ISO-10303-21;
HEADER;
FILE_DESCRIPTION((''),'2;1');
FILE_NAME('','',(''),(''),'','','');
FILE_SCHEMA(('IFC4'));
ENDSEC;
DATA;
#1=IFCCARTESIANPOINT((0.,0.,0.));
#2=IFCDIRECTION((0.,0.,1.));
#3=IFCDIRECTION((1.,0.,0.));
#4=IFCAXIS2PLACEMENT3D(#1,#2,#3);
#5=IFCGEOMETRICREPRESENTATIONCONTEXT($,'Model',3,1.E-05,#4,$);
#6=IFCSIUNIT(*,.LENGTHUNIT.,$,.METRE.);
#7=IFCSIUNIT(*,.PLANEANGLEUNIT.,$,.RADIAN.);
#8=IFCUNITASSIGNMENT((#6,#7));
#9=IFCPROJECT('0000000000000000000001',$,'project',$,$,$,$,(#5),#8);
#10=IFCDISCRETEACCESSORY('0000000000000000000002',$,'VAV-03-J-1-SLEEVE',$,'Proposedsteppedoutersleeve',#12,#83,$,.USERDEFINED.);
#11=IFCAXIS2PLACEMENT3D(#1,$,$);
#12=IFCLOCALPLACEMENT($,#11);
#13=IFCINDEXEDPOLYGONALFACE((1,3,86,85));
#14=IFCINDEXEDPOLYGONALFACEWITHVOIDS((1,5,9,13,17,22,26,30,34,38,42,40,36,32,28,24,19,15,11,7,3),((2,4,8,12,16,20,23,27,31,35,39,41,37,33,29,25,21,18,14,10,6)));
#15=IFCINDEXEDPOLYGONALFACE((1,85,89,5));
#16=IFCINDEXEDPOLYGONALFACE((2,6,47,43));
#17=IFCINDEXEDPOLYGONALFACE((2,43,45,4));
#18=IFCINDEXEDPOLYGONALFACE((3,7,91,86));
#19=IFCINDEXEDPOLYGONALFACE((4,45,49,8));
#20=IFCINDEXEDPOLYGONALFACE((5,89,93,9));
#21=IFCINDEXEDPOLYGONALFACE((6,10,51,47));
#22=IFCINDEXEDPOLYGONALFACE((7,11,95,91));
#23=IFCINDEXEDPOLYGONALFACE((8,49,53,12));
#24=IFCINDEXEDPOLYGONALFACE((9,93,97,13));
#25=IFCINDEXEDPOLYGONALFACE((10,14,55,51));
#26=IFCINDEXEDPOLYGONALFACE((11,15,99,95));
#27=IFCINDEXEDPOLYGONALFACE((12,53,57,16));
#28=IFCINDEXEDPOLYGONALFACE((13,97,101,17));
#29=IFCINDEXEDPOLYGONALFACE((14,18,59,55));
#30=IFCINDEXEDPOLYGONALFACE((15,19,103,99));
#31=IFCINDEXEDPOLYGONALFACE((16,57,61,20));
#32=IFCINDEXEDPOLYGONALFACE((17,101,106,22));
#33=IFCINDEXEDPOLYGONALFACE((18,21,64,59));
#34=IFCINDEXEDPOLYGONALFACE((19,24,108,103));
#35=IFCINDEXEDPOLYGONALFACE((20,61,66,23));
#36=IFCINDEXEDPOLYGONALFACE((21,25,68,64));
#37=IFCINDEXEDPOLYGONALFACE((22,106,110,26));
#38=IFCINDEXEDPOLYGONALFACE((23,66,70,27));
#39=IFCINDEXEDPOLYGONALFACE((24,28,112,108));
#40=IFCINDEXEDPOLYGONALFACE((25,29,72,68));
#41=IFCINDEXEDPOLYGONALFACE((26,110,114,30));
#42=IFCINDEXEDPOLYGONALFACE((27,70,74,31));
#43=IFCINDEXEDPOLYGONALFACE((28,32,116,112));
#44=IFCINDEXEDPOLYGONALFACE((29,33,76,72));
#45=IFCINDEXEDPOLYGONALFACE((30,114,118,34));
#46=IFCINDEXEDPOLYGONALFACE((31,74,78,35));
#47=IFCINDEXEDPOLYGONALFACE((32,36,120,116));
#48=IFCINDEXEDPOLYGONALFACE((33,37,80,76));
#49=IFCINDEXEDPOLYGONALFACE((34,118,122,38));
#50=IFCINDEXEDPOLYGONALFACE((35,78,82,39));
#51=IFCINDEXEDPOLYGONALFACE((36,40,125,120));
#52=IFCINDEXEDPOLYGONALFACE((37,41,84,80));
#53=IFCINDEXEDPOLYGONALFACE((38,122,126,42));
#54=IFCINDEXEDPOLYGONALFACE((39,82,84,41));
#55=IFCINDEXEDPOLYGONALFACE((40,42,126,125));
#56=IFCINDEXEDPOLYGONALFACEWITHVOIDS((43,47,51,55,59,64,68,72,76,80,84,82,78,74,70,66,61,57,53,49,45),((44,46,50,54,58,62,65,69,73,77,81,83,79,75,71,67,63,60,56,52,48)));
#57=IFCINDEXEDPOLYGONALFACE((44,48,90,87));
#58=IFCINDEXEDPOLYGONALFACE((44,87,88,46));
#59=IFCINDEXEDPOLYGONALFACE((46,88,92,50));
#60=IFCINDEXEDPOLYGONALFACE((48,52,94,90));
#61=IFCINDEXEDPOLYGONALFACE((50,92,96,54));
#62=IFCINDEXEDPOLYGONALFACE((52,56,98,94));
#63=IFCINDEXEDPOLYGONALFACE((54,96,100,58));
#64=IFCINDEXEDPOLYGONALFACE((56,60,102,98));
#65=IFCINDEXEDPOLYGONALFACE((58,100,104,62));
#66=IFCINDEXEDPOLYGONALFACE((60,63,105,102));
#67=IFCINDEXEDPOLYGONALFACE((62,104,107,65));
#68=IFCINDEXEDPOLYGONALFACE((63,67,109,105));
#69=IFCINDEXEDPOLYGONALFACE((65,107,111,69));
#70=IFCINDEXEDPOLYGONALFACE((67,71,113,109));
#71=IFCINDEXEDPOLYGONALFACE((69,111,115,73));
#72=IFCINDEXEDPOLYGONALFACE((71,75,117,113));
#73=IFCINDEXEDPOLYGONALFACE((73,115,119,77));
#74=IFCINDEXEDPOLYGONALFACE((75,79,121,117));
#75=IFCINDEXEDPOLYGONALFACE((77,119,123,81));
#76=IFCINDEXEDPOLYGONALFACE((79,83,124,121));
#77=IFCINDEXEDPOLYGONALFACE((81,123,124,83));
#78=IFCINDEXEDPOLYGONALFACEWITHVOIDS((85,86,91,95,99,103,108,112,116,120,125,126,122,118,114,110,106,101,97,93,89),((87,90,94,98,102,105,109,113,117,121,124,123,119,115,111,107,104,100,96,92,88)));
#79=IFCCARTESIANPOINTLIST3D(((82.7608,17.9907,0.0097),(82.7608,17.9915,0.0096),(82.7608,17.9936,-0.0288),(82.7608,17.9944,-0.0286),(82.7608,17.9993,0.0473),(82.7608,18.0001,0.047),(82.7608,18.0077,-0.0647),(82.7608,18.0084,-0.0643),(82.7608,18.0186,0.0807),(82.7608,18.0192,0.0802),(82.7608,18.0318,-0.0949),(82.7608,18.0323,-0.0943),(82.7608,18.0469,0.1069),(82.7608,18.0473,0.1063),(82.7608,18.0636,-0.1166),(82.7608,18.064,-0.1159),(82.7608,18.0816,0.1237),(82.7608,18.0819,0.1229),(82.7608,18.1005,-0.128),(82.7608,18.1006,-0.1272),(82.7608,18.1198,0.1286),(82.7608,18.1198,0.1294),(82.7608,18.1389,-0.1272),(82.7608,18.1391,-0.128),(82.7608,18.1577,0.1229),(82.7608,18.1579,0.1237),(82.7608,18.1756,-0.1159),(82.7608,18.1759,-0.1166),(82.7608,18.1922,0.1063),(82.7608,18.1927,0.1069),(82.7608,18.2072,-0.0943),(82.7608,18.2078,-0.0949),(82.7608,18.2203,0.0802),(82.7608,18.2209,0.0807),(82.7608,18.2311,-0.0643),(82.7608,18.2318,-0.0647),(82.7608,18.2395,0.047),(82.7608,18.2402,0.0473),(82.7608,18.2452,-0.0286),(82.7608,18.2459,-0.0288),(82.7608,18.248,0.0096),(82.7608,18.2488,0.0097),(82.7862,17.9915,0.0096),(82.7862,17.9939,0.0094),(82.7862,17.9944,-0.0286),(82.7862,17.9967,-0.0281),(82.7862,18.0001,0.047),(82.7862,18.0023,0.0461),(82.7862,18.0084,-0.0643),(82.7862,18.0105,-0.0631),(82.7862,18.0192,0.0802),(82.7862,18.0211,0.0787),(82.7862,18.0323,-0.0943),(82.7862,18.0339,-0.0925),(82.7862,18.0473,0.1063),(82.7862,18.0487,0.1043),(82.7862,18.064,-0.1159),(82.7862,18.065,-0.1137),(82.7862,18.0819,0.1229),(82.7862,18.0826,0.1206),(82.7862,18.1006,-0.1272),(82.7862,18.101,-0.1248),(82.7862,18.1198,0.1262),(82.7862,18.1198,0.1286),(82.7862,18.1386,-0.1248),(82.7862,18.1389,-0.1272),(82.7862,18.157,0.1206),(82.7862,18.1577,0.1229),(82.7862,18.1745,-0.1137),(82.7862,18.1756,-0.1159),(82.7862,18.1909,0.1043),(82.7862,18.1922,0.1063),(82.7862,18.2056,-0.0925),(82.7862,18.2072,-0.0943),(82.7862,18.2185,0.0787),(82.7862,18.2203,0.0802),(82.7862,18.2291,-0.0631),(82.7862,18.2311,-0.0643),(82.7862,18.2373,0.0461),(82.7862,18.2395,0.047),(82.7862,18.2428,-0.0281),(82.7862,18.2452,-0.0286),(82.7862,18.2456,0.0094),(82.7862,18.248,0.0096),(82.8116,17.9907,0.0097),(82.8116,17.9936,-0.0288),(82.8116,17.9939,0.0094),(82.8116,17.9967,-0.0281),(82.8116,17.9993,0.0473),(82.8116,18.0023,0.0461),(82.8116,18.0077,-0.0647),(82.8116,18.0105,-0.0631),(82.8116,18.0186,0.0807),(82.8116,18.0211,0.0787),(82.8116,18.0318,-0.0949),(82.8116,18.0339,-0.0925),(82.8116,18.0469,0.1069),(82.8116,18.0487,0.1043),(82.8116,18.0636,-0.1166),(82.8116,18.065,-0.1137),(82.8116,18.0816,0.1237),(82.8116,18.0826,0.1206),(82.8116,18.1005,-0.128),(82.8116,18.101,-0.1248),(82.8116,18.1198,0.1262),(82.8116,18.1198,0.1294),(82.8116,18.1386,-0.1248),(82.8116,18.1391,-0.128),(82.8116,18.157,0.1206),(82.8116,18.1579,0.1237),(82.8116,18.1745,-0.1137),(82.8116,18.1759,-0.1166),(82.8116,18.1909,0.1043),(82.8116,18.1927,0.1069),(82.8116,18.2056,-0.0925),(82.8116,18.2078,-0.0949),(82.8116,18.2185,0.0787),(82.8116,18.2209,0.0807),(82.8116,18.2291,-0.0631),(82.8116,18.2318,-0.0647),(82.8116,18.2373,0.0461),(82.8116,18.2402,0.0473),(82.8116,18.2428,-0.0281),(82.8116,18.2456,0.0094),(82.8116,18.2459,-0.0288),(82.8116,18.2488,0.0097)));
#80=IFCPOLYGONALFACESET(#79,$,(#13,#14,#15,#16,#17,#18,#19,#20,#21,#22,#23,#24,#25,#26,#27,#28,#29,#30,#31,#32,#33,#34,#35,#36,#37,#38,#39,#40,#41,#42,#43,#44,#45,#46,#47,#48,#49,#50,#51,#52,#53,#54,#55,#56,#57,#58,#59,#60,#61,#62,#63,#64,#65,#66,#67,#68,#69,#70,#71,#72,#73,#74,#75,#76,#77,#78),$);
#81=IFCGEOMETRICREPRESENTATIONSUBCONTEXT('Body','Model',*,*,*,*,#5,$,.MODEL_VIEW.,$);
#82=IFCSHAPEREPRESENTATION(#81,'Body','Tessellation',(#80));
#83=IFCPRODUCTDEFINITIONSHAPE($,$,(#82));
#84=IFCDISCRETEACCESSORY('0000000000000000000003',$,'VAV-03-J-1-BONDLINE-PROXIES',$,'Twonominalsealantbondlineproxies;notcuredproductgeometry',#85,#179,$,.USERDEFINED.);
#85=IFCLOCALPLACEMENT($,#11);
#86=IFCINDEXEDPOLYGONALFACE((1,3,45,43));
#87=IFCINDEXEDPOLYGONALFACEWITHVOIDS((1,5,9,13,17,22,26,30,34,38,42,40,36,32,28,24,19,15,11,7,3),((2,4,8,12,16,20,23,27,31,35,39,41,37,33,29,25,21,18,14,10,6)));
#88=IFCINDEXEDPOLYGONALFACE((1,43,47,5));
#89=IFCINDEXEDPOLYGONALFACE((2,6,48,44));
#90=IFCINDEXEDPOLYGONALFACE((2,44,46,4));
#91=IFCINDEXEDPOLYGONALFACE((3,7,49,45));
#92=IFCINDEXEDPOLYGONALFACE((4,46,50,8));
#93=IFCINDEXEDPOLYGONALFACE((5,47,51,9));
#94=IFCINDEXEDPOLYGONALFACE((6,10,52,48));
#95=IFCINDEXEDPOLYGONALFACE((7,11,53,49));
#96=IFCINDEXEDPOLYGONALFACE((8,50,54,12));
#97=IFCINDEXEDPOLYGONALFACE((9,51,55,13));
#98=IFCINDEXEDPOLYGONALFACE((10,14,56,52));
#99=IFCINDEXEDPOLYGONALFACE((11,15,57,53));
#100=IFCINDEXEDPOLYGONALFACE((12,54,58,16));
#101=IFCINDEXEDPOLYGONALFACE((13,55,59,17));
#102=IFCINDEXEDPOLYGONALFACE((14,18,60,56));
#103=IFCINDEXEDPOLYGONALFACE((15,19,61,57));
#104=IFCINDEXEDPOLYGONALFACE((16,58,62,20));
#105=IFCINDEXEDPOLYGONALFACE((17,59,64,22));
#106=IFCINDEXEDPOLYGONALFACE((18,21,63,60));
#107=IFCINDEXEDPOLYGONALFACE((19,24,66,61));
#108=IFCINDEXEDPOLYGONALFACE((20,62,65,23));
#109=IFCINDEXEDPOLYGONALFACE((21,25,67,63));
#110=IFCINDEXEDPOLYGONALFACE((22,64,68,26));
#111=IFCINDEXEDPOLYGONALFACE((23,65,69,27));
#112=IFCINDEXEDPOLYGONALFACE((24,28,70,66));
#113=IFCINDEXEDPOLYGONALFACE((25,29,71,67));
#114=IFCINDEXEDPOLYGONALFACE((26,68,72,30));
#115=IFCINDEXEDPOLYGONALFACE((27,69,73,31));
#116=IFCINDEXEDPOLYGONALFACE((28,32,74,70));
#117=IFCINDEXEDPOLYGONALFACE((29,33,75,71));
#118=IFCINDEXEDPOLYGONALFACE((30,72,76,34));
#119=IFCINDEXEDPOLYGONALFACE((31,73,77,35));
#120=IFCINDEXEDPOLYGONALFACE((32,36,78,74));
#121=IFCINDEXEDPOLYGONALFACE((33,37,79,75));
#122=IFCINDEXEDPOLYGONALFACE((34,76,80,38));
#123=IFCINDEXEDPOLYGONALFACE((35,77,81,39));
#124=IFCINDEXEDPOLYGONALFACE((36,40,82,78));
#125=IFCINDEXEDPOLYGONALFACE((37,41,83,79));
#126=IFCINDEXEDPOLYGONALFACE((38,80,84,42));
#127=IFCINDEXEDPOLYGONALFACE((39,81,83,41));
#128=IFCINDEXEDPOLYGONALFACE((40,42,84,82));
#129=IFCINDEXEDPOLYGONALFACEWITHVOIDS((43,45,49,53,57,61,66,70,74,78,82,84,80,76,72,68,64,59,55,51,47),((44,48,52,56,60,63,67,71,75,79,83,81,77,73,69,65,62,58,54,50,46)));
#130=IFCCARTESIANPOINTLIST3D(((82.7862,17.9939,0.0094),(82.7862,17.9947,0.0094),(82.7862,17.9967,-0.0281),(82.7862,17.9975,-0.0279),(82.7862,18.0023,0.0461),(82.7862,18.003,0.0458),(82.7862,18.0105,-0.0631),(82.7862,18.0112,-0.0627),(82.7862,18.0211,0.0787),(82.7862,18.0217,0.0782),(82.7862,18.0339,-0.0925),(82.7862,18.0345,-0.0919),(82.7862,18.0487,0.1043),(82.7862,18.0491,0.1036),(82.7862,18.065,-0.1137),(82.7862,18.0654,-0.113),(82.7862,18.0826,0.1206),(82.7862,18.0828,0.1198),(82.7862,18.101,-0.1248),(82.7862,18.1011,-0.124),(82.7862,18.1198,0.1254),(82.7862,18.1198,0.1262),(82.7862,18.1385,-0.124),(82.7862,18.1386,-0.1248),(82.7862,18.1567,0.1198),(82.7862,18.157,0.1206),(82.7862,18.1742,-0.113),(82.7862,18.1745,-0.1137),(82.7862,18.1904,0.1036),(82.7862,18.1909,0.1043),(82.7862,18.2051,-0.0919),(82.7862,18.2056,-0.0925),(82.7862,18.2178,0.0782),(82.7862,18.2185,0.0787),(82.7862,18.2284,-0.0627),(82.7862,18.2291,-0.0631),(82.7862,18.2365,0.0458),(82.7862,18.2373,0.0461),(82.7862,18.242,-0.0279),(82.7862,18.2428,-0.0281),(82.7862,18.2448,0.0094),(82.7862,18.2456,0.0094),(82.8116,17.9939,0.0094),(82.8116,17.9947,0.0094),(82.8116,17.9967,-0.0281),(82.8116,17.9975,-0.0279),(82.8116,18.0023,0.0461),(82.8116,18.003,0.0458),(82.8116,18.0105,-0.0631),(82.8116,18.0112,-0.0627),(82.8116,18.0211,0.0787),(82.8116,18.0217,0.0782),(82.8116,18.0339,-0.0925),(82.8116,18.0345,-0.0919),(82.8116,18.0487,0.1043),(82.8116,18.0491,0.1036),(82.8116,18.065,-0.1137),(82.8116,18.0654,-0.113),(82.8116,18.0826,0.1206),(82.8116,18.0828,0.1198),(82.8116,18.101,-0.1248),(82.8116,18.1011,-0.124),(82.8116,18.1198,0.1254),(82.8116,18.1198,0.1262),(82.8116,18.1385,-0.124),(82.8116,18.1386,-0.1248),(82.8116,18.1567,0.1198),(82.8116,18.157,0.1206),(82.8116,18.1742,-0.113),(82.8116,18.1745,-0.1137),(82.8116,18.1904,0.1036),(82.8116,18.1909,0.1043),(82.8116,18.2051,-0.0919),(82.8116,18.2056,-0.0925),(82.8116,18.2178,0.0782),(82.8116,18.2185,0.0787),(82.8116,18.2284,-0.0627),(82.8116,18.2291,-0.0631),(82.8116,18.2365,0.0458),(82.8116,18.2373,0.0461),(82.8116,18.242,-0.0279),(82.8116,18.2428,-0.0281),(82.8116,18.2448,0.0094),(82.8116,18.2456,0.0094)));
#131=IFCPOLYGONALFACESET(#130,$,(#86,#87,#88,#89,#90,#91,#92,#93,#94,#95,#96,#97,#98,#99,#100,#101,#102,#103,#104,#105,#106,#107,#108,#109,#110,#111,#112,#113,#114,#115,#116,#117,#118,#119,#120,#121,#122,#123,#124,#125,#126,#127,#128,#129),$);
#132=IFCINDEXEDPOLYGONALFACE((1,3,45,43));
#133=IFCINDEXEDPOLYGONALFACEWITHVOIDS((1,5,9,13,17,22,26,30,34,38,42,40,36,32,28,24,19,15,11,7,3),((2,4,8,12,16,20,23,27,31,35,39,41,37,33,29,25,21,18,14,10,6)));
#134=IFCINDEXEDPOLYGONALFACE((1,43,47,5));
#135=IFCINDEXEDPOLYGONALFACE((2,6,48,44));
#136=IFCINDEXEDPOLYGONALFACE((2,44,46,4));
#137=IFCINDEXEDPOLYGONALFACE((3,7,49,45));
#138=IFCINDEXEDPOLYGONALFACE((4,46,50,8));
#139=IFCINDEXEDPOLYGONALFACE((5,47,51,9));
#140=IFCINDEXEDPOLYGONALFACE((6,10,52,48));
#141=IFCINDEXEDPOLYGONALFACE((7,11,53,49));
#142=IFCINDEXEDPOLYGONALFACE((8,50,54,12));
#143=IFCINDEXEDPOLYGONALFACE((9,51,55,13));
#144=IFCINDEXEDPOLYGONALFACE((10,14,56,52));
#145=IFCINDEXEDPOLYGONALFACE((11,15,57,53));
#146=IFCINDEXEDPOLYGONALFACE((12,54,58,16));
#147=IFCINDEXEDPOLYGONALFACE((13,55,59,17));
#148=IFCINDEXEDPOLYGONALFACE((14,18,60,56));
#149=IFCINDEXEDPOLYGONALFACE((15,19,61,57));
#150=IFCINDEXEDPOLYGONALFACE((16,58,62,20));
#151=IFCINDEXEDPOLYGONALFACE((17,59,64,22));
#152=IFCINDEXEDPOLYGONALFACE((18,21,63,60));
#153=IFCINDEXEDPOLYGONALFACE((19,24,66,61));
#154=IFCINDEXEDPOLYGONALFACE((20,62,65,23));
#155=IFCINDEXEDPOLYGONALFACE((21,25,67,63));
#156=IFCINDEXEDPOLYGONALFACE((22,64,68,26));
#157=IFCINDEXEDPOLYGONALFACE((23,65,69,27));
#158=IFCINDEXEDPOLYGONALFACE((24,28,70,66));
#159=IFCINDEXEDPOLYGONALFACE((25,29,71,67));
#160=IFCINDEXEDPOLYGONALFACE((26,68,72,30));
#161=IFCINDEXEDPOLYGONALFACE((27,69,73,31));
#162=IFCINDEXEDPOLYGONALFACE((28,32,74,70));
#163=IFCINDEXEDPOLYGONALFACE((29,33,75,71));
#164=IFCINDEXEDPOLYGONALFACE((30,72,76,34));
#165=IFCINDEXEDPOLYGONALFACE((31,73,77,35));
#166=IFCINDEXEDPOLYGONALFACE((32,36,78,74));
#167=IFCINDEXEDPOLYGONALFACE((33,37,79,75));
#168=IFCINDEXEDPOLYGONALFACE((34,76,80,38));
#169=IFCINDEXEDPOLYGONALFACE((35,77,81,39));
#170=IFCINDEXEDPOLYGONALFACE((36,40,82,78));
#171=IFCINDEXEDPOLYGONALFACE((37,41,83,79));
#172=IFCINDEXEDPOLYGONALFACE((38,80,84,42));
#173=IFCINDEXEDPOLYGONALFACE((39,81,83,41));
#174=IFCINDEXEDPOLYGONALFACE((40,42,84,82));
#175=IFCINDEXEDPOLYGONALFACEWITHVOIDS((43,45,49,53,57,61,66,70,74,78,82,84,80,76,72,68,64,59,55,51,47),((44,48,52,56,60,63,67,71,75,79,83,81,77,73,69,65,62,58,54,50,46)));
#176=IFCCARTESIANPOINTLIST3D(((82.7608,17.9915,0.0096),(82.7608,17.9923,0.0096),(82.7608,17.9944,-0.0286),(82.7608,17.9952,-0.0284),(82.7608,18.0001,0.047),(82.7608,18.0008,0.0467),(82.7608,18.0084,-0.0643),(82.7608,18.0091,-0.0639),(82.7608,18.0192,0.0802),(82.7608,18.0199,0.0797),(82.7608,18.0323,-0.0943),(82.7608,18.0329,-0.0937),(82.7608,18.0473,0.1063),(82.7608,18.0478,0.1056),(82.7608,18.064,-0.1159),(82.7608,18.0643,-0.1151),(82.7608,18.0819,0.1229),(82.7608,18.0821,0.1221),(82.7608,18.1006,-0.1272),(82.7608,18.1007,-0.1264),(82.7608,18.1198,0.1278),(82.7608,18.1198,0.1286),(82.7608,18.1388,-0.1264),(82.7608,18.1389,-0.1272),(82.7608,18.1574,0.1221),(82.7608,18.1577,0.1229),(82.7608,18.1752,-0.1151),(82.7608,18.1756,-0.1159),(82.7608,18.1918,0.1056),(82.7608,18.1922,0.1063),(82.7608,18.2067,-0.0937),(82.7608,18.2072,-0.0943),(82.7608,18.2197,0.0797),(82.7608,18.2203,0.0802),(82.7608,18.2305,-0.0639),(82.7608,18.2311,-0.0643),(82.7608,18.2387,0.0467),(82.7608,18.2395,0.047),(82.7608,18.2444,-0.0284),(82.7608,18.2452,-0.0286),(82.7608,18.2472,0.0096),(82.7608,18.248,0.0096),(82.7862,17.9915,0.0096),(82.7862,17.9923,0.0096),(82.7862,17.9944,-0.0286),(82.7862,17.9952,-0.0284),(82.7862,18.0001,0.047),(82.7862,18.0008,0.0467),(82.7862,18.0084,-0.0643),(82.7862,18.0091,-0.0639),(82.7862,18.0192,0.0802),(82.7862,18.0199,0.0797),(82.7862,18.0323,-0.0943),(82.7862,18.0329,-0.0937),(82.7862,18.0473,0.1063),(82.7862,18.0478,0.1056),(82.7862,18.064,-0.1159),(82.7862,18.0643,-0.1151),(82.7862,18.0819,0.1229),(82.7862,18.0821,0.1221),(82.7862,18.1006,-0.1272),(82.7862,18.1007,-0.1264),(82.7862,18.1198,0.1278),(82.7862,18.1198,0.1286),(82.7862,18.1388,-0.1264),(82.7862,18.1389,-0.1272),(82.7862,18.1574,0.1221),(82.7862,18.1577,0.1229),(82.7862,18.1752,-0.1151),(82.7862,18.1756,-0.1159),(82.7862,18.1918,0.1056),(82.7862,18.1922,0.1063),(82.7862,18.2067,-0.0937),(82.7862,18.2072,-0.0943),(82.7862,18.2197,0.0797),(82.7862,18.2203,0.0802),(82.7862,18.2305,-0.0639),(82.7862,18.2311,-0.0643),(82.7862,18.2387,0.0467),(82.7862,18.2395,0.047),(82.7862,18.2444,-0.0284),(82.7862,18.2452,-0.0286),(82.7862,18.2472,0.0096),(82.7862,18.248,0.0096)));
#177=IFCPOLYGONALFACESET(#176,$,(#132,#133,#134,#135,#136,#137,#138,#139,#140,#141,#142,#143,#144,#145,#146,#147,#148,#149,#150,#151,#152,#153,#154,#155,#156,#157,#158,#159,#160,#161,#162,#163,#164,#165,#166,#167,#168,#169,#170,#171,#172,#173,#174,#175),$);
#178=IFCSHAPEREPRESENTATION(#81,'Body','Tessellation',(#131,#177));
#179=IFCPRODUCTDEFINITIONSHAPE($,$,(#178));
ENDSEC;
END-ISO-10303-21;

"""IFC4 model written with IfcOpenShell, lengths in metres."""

from ifc_helpers import new_model, entity, si_unit, frame, origin_with_axes, place, context, subcontext, project, element, save


model = new_model("IFC4")

# Units and contexts
model_context = context("Model", 3, precision=1e-05, world=origin_with_axes())
body_context = subcontext(model_context, "Body", "Model", "MODEL_VIEW")
ifc_project = project(units=[si_unit("LENGTHUNIT", "METRE"), si_unit("PLANEANGLEUNIT", "RADIAN")], contexts=[model_context])

# Discrete accessories
discrete_accessory_1_placement = place(None, frame((82.7862, 18.1198, 0.0), z_axis=(0.0, -1.0, 0.0), x_axis=(0.0, 0.0, 1.0)))
element("IfcDiscreteAccessory", 1, at=discrete_accessory_1_placement, Name="VAV-03-J-1-SLEEVE", ObjectType="Proposedsteppedoutersleeve", PredefinedType="USERDEFINED", context=body_context, shape_type="SweptSolid", body=[
    entity("IfcRevolvedAreaSolid", entity("IfcArbitraryClosedProfileDef", "AREA", None, entity("IfcPolyline", [entity("IfcCartesianPoint", [0.1262, -0.0254]), entity("IfcCartesianPoint", [0.1294, -0.0254]), entity("IfcCartesianPoint", [0.1294, 0.0254]), entity("IfcCartesianPoint", [0.1286, 0.0254]), entity("IfcCartesianPoint", [0.1286, 0.0]), entity("IfcCartesianPoint", [0.1262, 0.0]), entity("IfcCartesianPoint", [0.1262, -0.0254])])), entity("IfcAxis2Placement3D", entity("IfcCartesianPoint", [0.0, 0.0, 0.0])), entity("IfcAxis1Placement", entity("IfcCartesianPoint", [0.0, 0.0, 0.0]), entity("IfcDirection", [0.0, 1.0, 0.0])), 6.283185),
])
discrete_accessory_2_placement = place(None, frame((82.7862, 18.1198, 0.0), z_axis=(0.0, -1.0, 0.0), x_axis=(0.0, 0.0, 1.0)))
element("IfcDiscreteAccessory", 2, at=discrete_accessory_2_placement, Name="VAV-03-J-1-BONDLINE-PROXIES", ObjectType="Twonominalsealantbondlineproxies;notcuredproductgeometry", PredefinedType="USERDEFINED", context=body_context, shape_type="SweptSolid", body=[
    entity("IfcRevolvedAreaSolid", entity("IfcArbitraryClosedProfileDef", "AREA", None, entity("IfcPolyline", [entity("IfcCartesianPoint", [0.1254, -0.0254]), entity("IfcCartesianPoint", [0.1262, -0.0254]), entity("IfcCartesianPoint", [0.1262, 0.0]), entity("IfcCartesianPoint", [0.1254, 0.0]), entity("IfcCartesianPoint", [0.1254, -0.0254])])), entity("IfcAxis2Placement3D", entity("IfcCartesianPoint", [0.0, 0.0, 0.0])), entity("IfcAxis1Placement", entity("IfcCartesianPoint", [0.0, 0.0, 0.0]), entity("IfcDirection", [0.0, 1.0, 0.0])), 6.283185),
    entity("IfcRevolvedAreaSolid", entity("IfcArbitraryClosedProfileDef", "AREA", None, entity("IfcPolyline", [entity("IfcCartesianPoint", [0.1278, 0.0]), entity("IfcCartesianPoint", [0.1286, 0.0]), entity("IfcCartesianPoint", [0.1286, 0.0254]), entity("IfcCartesianPoint", [0.1278, 0.0254]), entity("IfcCartesianPoint", [0.1278, 0.0])])), entity("IfcAxis2Placement3D", entity("IfcCartesianPoint", [0.0, 0.0, 0.0])), entity("IfcAxis1Placement", entity("IfcCartesianPoint", [0.0, 0.0, 0.0]), entity("IfcDirection", [0.0, 1.0, 0.0])), 6.283185),
])

save(model, "model.ifc")
